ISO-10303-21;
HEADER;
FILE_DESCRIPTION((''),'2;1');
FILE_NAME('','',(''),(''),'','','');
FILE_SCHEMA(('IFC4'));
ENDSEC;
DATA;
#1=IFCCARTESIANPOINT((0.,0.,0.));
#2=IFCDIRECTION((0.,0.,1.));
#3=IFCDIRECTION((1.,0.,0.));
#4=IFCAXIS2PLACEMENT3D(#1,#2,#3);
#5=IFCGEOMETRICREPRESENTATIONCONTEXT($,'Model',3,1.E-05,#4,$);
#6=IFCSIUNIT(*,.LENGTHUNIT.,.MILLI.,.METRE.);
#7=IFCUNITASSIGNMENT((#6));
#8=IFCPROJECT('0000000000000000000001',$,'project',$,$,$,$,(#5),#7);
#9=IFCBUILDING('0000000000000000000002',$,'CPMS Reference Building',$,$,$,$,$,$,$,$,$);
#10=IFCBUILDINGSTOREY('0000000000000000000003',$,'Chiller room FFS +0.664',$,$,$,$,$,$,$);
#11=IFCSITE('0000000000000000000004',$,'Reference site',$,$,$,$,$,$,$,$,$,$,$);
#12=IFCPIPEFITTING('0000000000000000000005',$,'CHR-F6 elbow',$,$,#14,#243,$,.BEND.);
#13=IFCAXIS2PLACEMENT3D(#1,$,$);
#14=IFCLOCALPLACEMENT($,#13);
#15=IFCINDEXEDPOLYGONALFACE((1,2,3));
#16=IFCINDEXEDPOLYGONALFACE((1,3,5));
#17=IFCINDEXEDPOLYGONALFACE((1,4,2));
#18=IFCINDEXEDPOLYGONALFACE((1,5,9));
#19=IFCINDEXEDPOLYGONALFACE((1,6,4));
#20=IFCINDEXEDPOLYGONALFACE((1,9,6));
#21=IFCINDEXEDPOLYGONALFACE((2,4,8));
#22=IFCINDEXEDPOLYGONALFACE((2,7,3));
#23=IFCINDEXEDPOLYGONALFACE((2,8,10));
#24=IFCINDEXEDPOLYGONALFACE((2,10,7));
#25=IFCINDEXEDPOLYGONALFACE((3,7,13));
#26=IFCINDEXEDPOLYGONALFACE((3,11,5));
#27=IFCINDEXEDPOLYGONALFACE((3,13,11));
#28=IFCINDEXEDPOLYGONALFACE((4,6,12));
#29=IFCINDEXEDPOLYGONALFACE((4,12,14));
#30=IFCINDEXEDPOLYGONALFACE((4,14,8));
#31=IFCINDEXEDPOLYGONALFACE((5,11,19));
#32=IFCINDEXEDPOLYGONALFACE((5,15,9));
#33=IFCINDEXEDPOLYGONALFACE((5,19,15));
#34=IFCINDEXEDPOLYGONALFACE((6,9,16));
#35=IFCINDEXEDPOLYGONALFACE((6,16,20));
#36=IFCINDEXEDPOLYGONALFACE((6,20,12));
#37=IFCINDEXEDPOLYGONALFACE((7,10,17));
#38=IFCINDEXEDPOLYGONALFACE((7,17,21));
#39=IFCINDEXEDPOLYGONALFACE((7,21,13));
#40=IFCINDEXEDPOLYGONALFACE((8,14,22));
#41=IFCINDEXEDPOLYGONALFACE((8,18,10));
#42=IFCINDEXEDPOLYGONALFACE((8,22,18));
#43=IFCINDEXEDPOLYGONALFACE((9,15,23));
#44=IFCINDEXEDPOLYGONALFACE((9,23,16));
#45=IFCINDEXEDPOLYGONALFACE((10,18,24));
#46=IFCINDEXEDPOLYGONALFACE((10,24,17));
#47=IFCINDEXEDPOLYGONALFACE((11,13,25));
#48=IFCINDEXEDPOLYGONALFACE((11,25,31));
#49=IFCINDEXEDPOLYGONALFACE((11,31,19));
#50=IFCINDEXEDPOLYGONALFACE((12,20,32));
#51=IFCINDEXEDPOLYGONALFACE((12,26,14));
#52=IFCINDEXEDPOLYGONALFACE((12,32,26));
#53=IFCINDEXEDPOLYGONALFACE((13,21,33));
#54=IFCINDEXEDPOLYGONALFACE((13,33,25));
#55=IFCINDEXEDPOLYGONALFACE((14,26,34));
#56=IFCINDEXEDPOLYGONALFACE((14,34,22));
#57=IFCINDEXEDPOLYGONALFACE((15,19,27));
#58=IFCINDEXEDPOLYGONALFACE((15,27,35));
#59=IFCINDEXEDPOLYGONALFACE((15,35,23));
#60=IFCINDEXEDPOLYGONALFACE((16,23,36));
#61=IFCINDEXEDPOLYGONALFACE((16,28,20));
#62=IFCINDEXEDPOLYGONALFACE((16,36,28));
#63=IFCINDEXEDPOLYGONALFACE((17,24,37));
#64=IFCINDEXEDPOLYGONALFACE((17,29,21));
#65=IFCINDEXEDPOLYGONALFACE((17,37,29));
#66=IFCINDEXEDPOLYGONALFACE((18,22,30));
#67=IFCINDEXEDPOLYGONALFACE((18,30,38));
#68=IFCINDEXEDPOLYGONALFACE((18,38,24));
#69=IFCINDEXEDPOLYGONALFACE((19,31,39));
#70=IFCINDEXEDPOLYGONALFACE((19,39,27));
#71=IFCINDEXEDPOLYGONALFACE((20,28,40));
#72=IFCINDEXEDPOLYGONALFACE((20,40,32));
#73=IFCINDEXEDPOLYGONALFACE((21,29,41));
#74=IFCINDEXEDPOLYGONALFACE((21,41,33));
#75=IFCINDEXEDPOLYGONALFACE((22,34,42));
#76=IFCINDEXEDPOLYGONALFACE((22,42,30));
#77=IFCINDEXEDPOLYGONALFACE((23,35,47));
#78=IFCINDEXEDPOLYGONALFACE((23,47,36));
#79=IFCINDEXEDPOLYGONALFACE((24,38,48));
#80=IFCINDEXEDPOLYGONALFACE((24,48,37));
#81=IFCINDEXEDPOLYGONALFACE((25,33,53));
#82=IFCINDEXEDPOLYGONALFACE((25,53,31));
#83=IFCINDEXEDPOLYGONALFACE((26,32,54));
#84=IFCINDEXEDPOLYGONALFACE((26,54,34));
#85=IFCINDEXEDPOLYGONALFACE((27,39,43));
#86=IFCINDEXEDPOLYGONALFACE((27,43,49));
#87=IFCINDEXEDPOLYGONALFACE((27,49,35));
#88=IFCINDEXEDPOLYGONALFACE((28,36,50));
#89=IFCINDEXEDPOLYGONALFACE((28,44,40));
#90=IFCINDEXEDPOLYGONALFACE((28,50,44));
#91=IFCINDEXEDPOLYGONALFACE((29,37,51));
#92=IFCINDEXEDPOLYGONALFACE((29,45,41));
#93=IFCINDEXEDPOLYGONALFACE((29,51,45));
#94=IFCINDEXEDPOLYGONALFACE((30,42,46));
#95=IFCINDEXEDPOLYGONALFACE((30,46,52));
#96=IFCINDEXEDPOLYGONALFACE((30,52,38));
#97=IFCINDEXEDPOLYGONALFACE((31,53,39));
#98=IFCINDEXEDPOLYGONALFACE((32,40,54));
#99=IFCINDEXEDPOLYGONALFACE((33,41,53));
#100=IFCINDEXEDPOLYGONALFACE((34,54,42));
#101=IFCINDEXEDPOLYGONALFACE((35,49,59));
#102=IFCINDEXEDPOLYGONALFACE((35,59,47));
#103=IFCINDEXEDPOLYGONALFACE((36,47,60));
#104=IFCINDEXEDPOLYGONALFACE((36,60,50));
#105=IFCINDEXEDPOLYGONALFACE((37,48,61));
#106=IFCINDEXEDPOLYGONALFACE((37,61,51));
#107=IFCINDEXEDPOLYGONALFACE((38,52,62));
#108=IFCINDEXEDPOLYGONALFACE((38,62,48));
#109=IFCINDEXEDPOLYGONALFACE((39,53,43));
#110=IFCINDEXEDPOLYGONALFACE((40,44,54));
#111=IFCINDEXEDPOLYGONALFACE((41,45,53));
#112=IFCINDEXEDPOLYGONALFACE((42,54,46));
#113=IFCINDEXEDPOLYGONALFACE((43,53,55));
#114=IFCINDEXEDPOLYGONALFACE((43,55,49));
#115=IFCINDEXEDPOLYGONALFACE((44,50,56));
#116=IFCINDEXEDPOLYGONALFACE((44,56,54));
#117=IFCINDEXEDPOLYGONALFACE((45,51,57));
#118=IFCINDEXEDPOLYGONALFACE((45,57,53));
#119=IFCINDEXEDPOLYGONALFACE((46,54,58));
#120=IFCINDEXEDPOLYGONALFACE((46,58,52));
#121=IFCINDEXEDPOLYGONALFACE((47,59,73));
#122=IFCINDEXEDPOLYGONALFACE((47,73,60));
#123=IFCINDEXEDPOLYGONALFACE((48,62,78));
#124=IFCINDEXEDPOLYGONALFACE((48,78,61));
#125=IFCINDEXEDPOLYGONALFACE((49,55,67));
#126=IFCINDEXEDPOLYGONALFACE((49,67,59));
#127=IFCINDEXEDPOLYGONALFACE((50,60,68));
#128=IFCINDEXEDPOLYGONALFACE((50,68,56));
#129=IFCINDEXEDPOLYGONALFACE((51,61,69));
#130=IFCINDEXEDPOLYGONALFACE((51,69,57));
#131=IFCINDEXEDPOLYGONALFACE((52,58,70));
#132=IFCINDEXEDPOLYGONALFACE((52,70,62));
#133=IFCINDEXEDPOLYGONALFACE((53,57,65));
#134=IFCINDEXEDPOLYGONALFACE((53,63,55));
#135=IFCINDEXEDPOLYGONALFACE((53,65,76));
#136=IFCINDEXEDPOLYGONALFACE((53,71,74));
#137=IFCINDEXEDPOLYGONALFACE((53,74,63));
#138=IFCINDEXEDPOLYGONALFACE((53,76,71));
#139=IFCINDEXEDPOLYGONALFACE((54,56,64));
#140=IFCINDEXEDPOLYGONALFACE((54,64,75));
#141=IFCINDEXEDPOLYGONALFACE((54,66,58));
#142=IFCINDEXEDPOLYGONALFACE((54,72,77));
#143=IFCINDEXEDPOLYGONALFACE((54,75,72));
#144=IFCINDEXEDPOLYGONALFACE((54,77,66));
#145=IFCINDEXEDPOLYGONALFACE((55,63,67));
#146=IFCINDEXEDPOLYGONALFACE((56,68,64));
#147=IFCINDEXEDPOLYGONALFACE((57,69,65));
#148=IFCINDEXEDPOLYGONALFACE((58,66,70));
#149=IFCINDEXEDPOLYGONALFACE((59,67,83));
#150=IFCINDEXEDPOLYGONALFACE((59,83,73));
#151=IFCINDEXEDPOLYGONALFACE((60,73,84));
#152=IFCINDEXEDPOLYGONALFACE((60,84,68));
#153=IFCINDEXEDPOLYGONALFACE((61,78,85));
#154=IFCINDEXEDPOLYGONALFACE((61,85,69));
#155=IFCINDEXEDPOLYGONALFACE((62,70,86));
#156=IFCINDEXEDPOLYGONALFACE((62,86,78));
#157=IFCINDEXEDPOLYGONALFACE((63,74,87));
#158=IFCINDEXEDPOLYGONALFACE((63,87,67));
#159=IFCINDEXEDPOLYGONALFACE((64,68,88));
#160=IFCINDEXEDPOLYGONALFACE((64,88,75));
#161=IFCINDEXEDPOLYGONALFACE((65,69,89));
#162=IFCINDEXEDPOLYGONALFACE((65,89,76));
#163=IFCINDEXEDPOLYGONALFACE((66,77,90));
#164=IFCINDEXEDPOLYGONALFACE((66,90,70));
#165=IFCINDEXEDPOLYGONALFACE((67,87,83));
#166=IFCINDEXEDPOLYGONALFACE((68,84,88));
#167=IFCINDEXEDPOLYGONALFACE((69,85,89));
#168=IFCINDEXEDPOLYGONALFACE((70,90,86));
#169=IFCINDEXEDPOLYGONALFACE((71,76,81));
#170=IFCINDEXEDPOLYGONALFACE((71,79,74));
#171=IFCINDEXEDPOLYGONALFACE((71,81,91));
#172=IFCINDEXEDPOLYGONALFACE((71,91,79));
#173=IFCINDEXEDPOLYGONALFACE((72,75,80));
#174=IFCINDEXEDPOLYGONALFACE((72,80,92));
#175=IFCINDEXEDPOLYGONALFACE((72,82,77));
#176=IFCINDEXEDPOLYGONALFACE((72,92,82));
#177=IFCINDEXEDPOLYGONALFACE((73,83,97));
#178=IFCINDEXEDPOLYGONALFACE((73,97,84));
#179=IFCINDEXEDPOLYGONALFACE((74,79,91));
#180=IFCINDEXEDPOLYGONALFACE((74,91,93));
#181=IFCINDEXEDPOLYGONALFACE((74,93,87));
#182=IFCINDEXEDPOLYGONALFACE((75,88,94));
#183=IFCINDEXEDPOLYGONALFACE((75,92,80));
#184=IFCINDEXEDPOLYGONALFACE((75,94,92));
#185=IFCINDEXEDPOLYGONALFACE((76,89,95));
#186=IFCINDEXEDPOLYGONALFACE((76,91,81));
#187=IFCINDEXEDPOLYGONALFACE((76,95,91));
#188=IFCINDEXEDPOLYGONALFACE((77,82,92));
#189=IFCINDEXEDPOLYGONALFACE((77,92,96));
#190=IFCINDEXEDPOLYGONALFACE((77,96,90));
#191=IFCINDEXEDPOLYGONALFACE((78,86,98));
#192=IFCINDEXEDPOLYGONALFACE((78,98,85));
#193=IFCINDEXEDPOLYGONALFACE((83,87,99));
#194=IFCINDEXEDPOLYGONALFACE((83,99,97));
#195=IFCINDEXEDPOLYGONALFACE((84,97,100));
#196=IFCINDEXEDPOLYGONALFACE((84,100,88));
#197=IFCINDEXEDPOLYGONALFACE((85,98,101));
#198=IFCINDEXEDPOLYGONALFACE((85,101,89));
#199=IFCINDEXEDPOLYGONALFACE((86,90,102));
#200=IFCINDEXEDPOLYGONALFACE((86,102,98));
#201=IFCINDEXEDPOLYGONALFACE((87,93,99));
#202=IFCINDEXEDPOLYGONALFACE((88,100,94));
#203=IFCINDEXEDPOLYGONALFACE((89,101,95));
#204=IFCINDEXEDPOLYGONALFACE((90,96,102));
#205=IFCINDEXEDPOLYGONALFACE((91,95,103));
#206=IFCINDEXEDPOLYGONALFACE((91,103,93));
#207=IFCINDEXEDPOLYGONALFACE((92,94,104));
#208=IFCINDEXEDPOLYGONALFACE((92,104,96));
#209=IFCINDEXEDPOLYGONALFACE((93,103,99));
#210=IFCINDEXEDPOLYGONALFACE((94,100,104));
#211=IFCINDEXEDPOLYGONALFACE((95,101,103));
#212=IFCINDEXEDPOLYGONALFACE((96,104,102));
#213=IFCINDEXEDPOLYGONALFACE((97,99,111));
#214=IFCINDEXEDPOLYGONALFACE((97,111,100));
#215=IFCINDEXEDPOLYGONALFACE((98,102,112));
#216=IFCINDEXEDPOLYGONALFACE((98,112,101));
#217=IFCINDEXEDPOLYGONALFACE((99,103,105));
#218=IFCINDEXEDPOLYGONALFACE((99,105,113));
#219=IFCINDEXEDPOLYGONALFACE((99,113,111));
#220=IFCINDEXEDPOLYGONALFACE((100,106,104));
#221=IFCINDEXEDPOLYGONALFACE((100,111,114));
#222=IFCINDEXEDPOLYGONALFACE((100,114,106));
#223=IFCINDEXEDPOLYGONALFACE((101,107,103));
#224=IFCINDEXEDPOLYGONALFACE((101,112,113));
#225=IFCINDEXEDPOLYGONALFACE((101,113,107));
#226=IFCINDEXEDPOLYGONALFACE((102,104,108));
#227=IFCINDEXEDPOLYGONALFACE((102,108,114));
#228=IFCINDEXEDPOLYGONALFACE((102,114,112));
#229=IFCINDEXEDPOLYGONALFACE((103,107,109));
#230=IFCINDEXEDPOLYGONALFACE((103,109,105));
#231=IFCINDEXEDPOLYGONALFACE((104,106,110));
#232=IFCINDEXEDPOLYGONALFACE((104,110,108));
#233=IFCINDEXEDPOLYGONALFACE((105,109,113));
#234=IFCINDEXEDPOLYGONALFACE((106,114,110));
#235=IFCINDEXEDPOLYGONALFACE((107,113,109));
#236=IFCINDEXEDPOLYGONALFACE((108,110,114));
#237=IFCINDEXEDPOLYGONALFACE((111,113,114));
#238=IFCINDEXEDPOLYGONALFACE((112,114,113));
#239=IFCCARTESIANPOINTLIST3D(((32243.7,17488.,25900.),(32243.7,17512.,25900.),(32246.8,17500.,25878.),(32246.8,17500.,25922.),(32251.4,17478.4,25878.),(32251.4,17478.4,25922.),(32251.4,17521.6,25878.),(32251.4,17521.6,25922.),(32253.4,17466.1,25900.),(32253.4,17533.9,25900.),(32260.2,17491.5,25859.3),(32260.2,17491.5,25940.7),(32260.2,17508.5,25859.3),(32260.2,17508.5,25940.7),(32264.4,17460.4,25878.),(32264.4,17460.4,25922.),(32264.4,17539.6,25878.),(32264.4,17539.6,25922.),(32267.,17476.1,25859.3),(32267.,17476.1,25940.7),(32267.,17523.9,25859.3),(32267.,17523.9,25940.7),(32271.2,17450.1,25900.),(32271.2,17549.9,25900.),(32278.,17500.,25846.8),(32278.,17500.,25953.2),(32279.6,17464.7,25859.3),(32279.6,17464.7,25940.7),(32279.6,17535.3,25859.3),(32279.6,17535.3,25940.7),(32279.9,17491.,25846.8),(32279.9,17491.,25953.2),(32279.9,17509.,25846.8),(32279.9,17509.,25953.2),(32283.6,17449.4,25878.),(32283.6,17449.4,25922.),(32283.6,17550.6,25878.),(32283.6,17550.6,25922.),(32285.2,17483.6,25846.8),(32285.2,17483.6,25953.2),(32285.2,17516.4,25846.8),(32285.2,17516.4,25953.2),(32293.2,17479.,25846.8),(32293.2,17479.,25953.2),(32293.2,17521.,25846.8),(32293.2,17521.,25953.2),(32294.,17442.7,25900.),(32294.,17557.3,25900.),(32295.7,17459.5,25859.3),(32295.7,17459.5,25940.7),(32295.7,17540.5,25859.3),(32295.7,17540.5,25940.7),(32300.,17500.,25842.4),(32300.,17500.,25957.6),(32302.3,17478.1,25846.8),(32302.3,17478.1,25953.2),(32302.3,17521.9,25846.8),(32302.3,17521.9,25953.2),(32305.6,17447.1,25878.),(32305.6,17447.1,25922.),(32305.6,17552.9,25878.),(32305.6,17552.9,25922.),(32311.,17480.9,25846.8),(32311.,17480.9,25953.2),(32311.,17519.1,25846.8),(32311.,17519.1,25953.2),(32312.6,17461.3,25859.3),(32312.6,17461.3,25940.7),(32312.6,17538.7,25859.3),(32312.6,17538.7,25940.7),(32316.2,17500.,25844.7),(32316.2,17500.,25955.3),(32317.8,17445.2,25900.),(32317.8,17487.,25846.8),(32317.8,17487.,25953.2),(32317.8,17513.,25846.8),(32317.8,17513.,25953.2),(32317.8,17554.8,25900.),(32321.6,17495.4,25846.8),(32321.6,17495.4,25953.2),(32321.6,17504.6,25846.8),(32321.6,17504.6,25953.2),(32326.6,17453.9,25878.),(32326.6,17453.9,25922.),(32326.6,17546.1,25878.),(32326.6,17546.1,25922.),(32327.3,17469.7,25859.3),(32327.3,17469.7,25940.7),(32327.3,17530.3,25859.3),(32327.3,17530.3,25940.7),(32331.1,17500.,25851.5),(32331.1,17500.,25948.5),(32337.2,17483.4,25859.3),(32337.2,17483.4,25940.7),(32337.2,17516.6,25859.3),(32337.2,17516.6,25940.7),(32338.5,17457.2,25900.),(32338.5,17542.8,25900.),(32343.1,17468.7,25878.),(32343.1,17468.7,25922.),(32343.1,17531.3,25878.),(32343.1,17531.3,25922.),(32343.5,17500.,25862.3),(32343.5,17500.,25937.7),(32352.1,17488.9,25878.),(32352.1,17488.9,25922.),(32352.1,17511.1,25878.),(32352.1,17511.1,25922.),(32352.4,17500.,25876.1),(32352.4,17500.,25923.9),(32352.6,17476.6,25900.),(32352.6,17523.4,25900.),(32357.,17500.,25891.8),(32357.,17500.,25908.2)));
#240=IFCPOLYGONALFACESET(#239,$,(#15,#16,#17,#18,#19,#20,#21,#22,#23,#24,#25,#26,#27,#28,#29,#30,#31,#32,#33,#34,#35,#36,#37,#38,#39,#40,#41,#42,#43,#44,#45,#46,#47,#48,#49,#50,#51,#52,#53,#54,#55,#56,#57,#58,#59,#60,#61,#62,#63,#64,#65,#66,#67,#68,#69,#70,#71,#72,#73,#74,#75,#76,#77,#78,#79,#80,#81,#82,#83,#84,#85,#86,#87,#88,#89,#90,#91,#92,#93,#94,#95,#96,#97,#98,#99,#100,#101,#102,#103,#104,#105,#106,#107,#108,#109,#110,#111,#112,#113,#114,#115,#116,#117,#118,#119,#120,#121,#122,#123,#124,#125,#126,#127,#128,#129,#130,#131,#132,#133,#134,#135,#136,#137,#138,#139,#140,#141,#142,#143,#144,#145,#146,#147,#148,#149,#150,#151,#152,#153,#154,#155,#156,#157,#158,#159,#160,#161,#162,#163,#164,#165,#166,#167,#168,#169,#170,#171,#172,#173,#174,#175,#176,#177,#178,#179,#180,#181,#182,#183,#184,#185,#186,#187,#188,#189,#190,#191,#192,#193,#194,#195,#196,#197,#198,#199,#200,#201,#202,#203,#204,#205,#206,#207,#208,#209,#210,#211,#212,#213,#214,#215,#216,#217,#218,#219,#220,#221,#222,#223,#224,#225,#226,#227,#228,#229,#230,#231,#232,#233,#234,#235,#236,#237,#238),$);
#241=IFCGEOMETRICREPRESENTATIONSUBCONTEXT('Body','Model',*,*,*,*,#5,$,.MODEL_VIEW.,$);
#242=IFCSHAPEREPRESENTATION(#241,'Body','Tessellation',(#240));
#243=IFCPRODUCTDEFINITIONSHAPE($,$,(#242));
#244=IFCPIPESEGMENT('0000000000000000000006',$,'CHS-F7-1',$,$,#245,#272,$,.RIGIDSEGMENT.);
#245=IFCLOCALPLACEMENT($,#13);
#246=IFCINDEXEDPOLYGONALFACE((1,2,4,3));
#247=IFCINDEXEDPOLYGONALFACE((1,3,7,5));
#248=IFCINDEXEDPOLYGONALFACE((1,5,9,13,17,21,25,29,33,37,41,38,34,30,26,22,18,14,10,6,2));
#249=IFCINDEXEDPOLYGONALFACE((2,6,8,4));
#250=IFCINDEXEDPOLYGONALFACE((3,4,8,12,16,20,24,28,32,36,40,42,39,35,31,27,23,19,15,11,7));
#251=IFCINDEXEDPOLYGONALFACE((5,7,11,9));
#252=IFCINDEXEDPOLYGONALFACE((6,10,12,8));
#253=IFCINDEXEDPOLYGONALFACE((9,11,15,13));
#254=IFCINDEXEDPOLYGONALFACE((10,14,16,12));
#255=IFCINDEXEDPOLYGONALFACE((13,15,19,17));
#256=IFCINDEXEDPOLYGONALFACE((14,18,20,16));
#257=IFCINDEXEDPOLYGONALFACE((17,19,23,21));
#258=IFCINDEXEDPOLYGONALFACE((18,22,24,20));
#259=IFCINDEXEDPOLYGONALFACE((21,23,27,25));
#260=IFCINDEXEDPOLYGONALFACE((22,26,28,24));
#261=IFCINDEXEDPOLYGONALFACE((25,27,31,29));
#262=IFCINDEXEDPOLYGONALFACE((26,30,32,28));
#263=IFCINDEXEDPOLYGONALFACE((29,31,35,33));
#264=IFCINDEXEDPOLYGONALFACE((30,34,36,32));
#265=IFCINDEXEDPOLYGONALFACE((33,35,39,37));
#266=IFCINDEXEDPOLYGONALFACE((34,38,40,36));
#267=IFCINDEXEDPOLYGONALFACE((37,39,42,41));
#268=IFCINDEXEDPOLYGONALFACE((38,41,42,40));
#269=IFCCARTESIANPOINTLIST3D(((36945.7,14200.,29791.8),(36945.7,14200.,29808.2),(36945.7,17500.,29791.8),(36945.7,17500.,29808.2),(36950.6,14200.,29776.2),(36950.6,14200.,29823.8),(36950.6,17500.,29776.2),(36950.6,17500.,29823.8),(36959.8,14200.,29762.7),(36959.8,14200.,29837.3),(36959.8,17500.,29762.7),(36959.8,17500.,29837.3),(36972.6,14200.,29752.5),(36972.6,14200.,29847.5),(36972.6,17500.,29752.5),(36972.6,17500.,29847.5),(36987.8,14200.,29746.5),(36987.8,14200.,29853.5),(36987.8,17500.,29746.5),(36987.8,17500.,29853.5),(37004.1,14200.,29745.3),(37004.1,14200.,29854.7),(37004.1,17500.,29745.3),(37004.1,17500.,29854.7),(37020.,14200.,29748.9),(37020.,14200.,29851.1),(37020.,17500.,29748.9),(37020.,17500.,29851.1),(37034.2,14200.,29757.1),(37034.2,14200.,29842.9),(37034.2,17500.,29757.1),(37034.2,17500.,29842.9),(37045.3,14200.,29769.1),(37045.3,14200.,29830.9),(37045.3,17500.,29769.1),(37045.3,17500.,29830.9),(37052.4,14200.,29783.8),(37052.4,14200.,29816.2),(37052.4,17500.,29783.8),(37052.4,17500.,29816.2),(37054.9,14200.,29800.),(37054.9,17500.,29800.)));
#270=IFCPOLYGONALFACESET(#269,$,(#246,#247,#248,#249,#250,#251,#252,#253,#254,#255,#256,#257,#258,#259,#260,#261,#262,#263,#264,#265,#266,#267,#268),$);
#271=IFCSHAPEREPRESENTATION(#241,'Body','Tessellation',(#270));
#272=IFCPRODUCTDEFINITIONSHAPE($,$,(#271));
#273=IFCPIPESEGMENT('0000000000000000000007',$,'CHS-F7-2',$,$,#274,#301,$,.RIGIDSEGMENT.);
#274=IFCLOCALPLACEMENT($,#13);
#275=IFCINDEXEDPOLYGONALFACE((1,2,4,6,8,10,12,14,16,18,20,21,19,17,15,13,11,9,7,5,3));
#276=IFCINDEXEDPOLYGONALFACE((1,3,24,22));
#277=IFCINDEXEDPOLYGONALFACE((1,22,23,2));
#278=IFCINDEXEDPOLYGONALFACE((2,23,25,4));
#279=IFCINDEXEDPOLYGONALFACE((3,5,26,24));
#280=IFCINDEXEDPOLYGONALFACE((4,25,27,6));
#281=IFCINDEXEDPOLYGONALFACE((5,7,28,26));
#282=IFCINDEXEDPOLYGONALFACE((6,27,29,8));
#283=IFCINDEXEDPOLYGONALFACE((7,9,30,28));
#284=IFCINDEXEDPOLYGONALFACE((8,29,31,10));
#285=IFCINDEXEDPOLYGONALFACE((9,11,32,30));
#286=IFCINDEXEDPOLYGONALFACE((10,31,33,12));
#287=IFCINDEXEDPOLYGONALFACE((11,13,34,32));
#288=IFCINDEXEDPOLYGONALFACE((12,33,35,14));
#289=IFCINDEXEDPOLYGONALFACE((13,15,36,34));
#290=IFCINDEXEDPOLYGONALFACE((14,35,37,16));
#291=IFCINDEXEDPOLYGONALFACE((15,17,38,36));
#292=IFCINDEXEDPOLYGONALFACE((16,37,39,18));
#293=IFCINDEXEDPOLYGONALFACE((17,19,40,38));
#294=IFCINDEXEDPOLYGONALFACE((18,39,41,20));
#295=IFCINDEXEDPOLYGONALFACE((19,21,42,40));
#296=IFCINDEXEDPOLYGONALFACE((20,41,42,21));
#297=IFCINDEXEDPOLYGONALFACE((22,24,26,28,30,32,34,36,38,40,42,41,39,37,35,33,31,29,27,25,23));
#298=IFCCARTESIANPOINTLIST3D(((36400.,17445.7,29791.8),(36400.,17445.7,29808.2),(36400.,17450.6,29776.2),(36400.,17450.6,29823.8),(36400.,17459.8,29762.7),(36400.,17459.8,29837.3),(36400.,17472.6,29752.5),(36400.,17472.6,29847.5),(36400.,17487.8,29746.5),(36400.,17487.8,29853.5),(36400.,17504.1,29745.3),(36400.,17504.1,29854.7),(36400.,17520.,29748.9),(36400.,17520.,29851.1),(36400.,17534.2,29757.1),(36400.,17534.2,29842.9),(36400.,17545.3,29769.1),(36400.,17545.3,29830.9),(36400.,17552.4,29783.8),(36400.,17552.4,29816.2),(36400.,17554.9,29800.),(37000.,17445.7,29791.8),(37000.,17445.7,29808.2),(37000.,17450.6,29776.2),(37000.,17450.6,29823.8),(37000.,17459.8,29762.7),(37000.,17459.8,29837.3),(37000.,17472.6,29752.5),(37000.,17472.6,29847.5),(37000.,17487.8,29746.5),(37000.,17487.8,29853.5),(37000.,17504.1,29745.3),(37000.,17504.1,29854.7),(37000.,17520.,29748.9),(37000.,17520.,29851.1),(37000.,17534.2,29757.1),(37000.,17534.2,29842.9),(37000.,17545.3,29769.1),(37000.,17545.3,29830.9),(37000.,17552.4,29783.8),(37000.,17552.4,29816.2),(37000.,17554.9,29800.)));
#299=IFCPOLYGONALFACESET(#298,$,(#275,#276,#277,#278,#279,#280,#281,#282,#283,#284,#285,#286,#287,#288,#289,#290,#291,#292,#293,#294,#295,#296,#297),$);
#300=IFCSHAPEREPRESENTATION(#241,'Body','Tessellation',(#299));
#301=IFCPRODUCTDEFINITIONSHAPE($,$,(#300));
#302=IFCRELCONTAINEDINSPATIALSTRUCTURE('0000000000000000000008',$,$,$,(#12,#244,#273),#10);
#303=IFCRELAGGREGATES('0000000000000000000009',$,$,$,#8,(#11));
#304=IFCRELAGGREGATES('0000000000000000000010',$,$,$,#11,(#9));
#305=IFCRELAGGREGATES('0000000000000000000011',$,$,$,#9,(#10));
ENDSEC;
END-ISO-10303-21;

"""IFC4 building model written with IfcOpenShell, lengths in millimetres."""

from ifc_helpers import new_model, entity, si_unit, frame, origin_with_axes, origin_2d, place, context, subcontext, project, spatial, circle_curve, outline, extrude, element, save


model = new_model("IFC4")

# Units and contexts
model_context = context("Model", 3, precision=1e-05, world=origin_with_axes())
body_context = subcontext(model_context, "Body", "Model", "MODEL_VIEW")
ifc_project = project(units=[si_unit("LENGTHUNIT", "METRE", prefix="MILLI")], contexts=[model_context])

# Site, building, storey
site = spatial("IfcSite", under=ifc_project, Name="Reference site")
building = spatial("IfcBuilding", under=site, Name="CPMS Reference Building")
storey = spatial("IfcBuildingStorey", under=building, Name="Chiller room FFS +0.664")

# Pipe fitting
pipe_fitting_1_placement = place(None, origin_with_axes())
element("IfcPipeFitting", 1, at=pipe_fitting_1_placement, inside=storey, Name="CHR-F6 elbow", PredefinedType="BEND", context=body_context, shape_type="CSG", body=[
    entity("IfcSphere", entity("IfcAxis2Placement3D", entity("IfcCartesianPoint", [32300.0, 17500.0, 25900.0]), entity("IfcDirection", [0.0, 0.0, 1.0]), entity("IfcDirection", [1.0, 0.0, 0.0])), 57.6),
])

# Pipe segments
pipe_segment_1_placement = place(None, origin_with_axes())
element("IfcPipeSegment", 2, at=pipe_segment_1_placement, inside=storey, Name="CHS-F7-1", PredefinedType="RIGIDSEGMENT", context=body_context, shape_type="SweptSolid", body=[
    extrude(outline(circle_curve(origin_2d(), 54.9)), frame((37000.0, 14200.0, 29800.0), z_axis=(0.0, 1.0, 0.0), x_axis=(1.0, 0.0, 0.0)), (0.0, 0.0, 1.0), 3300.0),
])
pipe_segment_2_placement = place(None, origin_with_axes())
element("IfcPipeSegment", 3, at=pipe_segment_2_placement, inside=storey, Name="CHS-F7-2", PredefinedType="RIGIDSEGMENT", context=body_context, shape_type="SweptSolid", body=[
    extrude(outline(circle_curve(origin_2d(), 54.9)), frame((37000.0, 17500.0, 29800.0), z_axis=(-1.0, 0.0, 0.0), x_axis=(0.0, 1.0, 0.0)), (0.0, 0.0, 1.0), 600.0),
])

save(model, "model.ifc")
